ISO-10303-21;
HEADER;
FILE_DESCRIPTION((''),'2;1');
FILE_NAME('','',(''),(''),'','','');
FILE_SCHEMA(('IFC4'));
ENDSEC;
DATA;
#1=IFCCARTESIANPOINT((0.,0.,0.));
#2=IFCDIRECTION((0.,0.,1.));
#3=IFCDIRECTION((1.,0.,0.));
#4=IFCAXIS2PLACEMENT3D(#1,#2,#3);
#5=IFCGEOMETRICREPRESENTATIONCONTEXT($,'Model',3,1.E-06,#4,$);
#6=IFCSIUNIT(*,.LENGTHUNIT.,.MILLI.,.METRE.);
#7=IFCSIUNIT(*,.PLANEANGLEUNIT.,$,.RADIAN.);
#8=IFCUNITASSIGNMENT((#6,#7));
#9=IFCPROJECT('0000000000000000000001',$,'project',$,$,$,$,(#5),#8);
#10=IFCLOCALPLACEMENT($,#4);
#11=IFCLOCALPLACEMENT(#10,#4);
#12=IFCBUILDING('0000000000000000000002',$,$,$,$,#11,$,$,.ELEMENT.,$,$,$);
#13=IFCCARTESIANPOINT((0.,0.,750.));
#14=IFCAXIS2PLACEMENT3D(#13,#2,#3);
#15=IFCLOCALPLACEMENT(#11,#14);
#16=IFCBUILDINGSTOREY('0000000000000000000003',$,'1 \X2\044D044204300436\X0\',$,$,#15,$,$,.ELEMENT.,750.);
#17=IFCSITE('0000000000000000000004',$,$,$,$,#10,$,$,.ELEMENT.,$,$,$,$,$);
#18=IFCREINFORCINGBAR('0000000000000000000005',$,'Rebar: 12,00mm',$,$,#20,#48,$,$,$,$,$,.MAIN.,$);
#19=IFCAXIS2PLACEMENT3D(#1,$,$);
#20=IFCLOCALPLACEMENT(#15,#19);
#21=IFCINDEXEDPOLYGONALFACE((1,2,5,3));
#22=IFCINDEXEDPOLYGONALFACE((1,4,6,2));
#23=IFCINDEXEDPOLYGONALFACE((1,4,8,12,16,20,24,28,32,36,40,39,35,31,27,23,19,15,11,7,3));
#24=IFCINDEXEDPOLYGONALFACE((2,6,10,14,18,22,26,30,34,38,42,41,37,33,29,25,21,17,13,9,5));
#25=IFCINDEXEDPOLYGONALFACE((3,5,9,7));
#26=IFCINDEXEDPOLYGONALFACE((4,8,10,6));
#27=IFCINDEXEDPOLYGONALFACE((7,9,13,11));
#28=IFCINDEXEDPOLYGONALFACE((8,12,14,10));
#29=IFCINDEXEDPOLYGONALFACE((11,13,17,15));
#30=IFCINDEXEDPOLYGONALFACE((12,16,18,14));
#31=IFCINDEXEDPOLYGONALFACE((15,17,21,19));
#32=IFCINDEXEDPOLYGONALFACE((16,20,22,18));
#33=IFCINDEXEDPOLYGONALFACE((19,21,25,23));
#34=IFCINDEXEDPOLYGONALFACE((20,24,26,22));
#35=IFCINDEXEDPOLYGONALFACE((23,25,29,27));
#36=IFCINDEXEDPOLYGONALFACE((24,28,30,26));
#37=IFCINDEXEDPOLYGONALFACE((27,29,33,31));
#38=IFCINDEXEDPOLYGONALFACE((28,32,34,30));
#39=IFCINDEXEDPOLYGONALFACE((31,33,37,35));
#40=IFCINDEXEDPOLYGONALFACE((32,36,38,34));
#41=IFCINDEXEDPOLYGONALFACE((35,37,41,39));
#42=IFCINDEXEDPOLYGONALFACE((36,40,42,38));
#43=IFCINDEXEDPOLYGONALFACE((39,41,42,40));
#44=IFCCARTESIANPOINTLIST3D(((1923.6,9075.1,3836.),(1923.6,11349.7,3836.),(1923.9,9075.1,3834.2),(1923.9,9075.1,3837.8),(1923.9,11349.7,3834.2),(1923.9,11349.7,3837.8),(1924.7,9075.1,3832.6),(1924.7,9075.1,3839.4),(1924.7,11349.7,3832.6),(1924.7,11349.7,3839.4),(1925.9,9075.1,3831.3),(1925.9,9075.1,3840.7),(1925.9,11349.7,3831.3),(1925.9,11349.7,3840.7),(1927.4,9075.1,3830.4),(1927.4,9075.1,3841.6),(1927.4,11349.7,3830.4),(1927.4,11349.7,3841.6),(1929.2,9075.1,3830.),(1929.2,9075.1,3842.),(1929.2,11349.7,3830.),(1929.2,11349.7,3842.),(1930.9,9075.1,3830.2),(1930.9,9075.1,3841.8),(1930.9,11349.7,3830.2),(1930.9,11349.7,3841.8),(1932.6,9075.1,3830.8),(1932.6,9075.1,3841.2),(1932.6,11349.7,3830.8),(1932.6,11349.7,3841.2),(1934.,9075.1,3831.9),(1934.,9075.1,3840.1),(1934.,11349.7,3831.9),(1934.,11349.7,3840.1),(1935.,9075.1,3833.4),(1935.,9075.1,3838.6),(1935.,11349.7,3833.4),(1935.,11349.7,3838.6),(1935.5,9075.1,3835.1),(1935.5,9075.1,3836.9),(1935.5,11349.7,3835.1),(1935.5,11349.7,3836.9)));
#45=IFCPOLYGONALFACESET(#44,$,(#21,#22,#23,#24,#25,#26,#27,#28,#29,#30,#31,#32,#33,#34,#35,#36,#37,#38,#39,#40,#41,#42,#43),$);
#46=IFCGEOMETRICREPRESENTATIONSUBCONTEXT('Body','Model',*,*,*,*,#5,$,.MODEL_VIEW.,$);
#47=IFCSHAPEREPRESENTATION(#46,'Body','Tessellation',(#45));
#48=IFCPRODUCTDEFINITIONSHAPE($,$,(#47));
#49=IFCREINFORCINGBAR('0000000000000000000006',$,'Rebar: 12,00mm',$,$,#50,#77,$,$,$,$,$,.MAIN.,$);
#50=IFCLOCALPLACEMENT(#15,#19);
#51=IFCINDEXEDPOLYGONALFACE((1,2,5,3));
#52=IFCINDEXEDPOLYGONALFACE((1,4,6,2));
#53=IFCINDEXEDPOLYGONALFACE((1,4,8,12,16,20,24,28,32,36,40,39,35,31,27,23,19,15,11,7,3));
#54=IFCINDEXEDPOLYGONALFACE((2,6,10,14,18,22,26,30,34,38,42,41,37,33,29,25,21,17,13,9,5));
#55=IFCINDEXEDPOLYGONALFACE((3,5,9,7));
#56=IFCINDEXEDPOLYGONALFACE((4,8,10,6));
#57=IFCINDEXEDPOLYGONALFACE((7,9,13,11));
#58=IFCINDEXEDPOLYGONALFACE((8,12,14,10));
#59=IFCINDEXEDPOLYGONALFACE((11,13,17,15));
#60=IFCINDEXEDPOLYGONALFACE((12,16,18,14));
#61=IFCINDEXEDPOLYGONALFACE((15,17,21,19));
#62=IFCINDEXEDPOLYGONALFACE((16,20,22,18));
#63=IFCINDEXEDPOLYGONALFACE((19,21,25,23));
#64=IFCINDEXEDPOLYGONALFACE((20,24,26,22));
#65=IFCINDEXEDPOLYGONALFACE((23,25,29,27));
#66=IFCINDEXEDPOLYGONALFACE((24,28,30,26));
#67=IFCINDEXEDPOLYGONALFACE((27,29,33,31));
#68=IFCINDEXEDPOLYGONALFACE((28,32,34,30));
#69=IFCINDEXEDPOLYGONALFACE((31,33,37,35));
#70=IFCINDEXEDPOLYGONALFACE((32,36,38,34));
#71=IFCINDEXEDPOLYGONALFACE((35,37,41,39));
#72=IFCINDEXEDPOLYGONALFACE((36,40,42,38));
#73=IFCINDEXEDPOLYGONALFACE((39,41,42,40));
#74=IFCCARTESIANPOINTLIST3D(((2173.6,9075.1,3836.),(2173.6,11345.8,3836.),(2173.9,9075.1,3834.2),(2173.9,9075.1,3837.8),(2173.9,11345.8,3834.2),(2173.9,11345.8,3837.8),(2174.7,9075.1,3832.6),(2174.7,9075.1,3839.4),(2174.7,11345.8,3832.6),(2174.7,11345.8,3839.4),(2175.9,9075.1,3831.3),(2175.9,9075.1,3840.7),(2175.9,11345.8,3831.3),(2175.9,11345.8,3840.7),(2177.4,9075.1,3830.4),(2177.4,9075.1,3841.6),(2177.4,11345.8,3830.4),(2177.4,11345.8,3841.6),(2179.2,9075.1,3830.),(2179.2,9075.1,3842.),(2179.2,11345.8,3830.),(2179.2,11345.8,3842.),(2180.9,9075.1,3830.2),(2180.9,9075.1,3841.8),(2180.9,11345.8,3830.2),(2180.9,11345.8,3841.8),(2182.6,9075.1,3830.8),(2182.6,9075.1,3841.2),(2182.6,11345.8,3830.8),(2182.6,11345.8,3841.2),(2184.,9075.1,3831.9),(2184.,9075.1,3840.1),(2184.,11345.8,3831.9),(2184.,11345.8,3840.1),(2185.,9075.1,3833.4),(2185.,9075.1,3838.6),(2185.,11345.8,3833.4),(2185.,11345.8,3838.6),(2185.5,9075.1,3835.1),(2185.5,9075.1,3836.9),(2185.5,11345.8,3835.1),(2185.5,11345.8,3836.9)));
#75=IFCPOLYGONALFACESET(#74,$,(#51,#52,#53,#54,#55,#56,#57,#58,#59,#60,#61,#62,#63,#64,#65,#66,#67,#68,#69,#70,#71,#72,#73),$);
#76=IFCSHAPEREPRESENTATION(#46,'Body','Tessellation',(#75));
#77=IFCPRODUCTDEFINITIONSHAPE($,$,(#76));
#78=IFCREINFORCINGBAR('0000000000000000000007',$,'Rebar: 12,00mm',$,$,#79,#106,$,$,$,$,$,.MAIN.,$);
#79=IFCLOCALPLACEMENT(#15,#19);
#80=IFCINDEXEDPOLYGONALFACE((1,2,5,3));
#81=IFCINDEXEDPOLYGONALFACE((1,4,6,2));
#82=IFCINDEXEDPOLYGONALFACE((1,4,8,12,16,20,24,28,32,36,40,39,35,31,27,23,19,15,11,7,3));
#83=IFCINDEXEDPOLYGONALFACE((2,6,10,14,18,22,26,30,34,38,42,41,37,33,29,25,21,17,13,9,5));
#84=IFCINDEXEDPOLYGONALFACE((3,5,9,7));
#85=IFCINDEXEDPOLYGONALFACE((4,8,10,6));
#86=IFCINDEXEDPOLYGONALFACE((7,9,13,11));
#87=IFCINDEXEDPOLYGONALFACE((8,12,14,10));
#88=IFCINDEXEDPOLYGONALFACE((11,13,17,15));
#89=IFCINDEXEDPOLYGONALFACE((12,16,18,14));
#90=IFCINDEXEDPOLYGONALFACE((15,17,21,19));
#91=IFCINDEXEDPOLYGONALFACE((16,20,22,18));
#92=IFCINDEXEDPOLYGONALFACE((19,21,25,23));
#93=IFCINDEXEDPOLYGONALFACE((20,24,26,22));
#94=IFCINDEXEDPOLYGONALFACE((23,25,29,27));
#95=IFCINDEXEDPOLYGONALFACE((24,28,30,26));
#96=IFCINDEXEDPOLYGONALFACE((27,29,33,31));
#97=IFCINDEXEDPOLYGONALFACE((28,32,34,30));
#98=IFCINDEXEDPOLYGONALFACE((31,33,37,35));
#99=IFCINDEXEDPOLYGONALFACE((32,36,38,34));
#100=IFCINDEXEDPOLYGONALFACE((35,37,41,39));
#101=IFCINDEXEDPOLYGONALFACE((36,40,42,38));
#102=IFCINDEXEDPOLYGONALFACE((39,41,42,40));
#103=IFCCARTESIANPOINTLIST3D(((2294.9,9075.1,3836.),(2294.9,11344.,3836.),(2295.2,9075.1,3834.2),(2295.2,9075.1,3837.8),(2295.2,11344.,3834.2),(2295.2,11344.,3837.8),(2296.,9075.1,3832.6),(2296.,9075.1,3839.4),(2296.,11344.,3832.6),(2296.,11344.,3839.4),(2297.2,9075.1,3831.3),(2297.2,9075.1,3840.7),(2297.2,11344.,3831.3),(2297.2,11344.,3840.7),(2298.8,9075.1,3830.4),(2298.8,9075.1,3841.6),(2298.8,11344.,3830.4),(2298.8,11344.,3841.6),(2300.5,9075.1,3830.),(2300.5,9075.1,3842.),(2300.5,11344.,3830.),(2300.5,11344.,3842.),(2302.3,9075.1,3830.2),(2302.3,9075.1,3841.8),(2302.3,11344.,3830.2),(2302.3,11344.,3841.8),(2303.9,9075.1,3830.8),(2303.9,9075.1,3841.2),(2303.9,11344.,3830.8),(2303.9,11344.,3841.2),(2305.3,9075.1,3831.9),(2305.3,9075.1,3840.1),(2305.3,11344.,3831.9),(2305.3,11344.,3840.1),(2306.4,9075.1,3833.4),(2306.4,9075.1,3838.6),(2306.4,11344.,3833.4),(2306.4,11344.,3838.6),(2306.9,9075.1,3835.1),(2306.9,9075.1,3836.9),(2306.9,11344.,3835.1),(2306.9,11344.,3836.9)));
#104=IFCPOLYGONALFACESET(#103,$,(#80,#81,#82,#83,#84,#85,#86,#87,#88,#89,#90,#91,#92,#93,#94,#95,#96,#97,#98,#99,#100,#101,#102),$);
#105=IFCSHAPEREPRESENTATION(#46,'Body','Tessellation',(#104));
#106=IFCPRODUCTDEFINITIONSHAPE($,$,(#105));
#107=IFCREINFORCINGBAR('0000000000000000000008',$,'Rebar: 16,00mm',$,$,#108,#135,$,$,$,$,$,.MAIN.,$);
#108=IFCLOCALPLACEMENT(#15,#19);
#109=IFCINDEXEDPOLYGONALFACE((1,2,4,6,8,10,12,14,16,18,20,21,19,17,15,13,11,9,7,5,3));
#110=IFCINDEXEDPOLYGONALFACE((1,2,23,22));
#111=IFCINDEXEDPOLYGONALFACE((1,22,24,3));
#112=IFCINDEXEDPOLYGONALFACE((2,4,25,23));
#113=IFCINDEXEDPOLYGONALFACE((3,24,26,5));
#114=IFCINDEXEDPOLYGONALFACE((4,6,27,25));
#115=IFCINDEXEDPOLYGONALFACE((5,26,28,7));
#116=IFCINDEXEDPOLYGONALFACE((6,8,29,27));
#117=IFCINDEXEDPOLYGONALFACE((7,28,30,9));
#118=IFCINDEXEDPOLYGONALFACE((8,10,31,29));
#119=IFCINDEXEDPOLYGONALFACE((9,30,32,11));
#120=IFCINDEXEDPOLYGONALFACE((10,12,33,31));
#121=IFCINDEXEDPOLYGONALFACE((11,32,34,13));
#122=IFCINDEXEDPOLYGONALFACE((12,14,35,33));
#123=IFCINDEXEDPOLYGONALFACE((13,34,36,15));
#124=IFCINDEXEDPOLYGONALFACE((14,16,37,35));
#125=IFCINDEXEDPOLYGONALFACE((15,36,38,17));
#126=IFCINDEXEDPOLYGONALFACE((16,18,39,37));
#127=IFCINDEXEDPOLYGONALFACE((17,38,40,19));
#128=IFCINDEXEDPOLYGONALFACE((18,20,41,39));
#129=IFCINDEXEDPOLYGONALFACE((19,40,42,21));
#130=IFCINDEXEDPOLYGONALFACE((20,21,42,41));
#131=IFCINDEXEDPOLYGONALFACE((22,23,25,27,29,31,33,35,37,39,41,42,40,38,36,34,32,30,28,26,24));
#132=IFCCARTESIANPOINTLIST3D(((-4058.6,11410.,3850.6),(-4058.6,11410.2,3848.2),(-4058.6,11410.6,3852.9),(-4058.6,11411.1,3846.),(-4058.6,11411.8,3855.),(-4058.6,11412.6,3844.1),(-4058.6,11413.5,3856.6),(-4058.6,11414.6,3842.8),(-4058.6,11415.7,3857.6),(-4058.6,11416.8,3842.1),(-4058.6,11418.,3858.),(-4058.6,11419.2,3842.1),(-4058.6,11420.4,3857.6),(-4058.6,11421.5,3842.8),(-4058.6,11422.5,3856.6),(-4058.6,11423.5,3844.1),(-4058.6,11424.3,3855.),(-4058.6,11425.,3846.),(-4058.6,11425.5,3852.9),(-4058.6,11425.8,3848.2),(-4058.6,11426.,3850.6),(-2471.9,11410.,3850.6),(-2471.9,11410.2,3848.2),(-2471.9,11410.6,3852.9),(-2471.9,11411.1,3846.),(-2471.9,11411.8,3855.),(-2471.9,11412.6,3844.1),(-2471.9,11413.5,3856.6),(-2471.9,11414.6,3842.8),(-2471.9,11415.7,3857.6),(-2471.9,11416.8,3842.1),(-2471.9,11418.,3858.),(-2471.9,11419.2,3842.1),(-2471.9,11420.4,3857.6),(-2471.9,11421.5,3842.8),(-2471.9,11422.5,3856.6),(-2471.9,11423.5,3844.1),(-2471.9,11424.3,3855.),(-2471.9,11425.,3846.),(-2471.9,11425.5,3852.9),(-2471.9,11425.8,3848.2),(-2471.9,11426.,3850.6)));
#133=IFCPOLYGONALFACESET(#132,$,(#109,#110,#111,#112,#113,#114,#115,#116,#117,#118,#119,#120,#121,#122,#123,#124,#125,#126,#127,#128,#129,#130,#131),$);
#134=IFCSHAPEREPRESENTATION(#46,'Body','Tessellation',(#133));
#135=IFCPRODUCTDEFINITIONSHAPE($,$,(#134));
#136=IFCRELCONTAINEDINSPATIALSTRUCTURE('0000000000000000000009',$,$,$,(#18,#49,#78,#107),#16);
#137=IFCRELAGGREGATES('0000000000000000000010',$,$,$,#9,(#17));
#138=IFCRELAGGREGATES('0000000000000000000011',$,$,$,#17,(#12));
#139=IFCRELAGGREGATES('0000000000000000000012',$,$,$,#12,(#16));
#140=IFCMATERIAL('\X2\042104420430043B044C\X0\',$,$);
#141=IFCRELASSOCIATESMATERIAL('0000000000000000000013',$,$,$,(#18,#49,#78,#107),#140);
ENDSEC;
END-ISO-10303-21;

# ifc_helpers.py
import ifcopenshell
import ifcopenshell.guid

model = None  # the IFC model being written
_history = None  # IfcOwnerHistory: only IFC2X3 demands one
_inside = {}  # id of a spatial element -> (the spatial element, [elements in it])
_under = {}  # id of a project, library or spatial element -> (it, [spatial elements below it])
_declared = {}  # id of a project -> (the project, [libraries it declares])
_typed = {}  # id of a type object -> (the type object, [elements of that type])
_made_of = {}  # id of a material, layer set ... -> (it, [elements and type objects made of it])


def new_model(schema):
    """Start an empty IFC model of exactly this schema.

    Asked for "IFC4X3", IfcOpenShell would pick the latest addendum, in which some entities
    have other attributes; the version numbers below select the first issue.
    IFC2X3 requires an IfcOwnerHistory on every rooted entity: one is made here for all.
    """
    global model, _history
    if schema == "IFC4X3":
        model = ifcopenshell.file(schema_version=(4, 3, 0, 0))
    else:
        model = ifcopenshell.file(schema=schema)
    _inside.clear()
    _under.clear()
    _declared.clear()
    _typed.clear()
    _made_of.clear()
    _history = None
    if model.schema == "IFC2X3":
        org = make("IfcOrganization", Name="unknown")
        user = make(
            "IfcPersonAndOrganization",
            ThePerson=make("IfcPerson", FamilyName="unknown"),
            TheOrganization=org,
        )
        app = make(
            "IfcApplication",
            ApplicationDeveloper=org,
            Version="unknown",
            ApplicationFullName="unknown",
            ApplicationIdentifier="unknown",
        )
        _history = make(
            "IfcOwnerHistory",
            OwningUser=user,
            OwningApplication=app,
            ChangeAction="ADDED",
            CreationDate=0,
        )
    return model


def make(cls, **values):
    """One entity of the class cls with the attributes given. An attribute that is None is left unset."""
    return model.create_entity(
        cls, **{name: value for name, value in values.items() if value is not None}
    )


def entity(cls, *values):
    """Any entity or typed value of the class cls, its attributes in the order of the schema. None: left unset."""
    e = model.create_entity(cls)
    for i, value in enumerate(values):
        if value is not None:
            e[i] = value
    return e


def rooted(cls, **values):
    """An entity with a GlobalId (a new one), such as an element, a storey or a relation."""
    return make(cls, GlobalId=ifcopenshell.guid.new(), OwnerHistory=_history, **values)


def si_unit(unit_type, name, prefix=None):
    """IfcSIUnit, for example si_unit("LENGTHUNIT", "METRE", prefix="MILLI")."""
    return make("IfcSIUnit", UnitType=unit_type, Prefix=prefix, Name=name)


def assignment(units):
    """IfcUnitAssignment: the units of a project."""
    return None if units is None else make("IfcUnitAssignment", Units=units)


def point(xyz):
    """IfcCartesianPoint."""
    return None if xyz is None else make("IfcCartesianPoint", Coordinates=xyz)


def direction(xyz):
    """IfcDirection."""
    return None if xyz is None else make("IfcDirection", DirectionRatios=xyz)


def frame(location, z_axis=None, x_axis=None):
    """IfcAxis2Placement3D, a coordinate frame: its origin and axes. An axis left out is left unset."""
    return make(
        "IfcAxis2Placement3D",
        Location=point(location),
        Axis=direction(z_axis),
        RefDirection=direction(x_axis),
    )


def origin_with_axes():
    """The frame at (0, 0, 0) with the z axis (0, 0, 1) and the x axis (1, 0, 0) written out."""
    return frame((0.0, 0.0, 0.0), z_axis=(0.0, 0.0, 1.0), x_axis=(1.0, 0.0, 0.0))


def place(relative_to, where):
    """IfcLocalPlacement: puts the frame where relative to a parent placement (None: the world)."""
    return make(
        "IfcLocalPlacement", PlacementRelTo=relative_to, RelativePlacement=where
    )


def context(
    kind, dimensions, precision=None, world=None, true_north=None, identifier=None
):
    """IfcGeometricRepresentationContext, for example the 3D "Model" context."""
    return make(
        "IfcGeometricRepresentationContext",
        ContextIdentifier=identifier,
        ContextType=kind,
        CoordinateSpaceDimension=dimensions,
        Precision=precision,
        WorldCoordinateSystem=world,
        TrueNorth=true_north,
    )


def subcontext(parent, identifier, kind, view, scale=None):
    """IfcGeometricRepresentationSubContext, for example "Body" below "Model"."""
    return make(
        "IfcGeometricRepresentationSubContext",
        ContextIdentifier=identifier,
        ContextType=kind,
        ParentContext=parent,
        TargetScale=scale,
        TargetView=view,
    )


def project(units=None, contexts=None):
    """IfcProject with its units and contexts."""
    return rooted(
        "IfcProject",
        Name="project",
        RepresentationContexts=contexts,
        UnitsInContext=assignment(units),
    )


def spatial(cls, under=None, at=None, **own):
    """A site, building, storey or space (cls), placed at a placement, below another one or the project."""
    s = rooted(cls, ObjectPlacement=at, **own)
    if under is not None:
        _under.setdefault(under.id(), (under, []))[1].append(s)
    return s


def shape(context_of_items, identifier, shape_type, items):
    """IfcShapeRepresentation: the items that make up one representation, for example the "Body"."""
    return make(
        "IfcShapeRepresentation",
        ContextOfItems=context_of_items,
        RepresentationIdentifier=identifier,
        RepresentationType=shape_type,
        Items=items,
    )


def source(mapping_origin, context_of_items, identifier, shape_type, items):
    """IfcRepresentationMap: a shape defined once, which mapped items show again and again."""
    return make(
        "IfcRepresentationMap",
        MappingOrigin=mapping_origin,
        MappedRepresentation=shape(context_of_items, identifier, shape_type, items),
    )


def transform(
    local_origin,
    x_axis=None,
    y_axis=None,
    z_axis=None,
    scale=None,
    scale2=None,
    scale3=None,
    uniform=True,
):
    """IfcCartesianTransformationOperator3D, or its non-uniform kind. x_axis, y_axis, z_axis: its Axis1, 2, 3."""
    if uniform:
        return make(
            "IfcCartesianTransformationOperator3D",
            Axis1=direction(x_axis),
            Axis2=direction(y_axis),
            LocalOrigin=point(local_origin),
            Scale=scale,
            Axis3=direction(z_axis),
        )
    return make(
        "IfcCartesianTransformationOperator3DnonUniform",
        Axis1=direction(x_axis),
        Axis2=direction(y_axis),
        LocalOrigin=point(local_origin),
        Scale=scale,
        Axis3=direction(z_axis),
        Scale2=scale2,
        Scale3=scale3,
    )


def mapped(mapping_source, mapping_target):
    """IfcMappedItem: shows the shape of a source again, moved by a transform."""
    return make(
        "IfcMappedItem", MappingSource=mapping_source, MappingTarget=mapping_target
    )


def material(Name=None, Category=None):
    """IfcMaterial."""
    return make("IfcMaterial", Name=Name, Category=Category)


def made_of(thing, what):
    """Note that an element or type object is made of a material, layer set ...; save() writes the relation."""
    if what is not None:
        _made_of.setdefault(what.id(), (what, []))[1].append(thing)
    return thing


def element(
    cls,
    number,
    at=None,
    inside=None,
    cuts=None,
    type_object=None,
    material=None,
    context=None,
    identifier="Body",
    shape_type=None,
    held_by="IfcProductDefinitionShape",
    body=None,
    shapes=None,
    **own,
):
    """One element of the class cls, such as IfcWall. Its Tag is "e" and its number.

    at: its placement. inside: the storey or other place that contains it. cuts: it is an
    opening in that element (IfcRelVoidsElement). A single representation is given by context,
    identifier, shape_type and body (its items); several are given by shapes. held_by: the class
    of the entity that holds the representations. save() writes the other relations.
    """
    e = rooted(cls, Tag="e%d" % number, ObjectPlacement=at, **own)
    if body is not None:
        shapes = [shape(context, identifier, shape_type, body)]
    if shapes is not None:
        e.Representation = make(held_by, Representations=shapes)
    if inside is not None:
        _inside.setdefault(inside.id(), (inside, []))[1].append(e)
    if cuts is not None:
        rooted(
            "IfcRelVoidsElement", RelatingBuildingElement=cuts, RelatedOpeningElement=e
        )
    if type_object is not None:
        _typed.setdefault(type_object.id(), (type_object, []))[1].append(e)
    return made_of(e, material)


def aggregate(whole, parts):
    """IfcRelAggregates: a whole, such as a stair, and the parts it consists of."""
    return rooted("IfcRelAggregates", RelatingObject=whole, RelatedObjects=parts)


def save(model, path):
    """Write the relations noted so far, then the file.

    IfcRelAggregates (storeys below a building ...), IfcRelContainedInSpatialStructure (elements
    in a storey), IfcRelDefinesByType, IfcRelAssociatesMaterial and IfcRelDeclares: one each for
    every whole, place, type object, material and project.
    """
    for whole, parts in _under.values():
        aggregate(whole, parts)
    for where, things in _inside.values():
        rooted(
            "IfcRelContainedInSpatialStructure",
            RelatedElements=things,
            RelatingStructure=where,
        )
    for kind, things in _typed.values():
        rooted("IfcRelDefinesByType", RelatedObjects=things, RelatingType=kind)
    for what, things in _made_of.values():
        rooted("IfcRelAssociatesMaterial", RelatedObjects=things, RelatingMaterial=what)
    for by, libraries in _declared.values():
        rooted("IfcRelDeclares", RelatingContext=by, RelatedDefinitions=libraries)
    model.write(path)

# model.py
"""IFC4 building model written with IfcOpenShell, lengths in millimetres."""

from ifc_helpers import new_model, entity, si_unit, frame, origin_with_axes, place, context, subcontext, project, spatial, source, transform, mapped, material, element, save


model = new_model("IFC4")

# Units and contexts
model_context = context("Model", 3, precision=1e-06, world=origin_with_axes())
body_context = subcontext(model_context, "Body", "Model", "MODEL_VIEW")
ifc_project = project(units=[si_unit("LENGTHUNIT", "METRE", prefix="MILLI"), si_unit("PLANEANGLEUNIT", "RADIAN")], contexts=[model_context])

# Site, building, storey
site_placement = place(None, origin_with_axes())
site = spatial("IfcSite", under=ifc_project, at=site_placement, CompositionType="ELEMENT")
building_placement = place(site_placement, origin_with_axes())
building = spatial("IfcBuilding", under=site, at=building_placement, CompositionType="ELEMENT")
storey_placement = place(building_placement, frame((0.0, 0.0, 750.0), z_axis=(0.0, 0.0, 1.0), x_axis=(1.0, 0.0, 0.0)))
storey = spatial("IfcBuildingStorey", under=building, at=storey_placement, Name="1 этаж", CompositionType="ELEMENT", Elevation=750.0)

# Reinforcing bars
ifc_material = material(Name="Сталь")
shared_shape_1 = source(origin_with_axes(), body_context, "Body", "AdvancedSweptSolid", [
    entity("IfcSweptDiskSolid", entity("IfcIndexedPolyCurve", entity("IfcCartesianPointList3D", [[0.0, 0.0, 0.0], [2274.6, 0.0, 0.0]]), [entity("IfcLineIndex", [1, 2])]), 6.0),
])
reinforcing_bar_1_placement = place(storey_placement, origin_with_axes())
element("IfcReinforcingBar", 1, at=reinforcing_bar_1_placement, inside=storey, material=ifc_material, Name="Rebar: 12,00mm", PredefinedType="MAIN", context=body_context, shape_type="MappedRepresentation", body=[
    mapped(shared_shape_1, transform((1929.6, 9075.1, 3836.0), x_axis=(0.0, 1.0, 0.0), y_axis=(-1.0, 0.0, 0.0), z_axis=(0.0, 0.0, 1.0), scale=1.0)),
])
shared_shape_2 = source(origin_with_axes(), body_context, "Body", "AdvancedSweptSolid", [
    entity("IfcSweptDiskSolid", entity("IfcIndexedPolyCurve", entity("IfcCartesianPointList3D", [[0.0, 0.0, 0.0], [2270.7, 0.0, 0.0]]), [entity("IfcLineIndex", [1, 2])]), 6.0),
])
reinforcing_bar_2_placement = place(storey_placement, origin_with_axes())
element("IfcReinforcingBar", 2, at=reinforcing_bar_2_placement, inside=storey, material=ifc_material, Name="Rebar: 12,00mm", PredefinedType="MAIN", context=body_context, shape_type="MappedRepresentation", body=[
    mapped(shared_shape_2, transform((2179.6, 9075.1, 3836.0), x_axis=(0.0, 1.0, 0.0), y_axis=(-1.0, 0.0, 0.0), z_axis=(0.0, 0.0, 1.0), scale=1.0)),
])
shared_shape_3 = source(origin_with_axes(), body_context, "Body", "AdvancedSweptSolid", [
    entity("IfcSweptDiskSolid", entity("IfcIndexedPolyCurve", entity("IfcCartesianPointList3D", [[0.0, 0.0, 0.0], [2268.8, 0.0, 0.0]]), [entity("IfcLineIndex", [1, 2])]), 6.0),
])
reinforcing_bar_3_placement = place(storey_placement, origin_with_axes())
element("IfcReinforcingBar", 3, at=reinforcing_bar_3_placement, inside=storey, material=ifc_material, Name="Rebar: 12,00mm", PredefinedType="MAIN", context=body_context, shape_type="MappedRepresentation", body=[
    mapped(shared_shape_3, transform((2300.9, 9075.1, 3836.0), x_axis=(0.0, 1.0, 0.0), y_axis=(-1.0, 0.0, 0.0), z_axis=(0.0, 0.0, 1.0), scale=1.0)),
])
shared_shape_4 = source(origin_with_axes(), body_context, "Body", "AdvancedSweptSolid", [
    entity("IfcSweptDiskSolid", entity("IfcIndexedPolyCurve", entity("IfcCartesianPointList3D", [[0.0, 0.0, 0.0], [1586.7, 0.0, 0.0]]), [entity("IfcLineIndex", [1, 2])]), 8.0),
])
reinforcing_bar_4_placement = place(storey_placement, origin_with_axes())
element("IfcReinforcingBar", 4, at=reinforcing_bar_4_placement, inside=storey, material=ifc_material, Name="Rebar: 16,00mm", PredefinedType="MAIN", context=body_context, shape_type="MappedRepresentation", body=[
    mapped(shared_shape_4, transform((-4058.6, 11418.0, 3850.0), x_axis=(1.0, 0.0, 0.0), y_axis=(0.0, 1.0, 0.0), z_axis=(0.0, 0.0, 1.0), scale=1.0)),
])

save(model, "model.ifc")
